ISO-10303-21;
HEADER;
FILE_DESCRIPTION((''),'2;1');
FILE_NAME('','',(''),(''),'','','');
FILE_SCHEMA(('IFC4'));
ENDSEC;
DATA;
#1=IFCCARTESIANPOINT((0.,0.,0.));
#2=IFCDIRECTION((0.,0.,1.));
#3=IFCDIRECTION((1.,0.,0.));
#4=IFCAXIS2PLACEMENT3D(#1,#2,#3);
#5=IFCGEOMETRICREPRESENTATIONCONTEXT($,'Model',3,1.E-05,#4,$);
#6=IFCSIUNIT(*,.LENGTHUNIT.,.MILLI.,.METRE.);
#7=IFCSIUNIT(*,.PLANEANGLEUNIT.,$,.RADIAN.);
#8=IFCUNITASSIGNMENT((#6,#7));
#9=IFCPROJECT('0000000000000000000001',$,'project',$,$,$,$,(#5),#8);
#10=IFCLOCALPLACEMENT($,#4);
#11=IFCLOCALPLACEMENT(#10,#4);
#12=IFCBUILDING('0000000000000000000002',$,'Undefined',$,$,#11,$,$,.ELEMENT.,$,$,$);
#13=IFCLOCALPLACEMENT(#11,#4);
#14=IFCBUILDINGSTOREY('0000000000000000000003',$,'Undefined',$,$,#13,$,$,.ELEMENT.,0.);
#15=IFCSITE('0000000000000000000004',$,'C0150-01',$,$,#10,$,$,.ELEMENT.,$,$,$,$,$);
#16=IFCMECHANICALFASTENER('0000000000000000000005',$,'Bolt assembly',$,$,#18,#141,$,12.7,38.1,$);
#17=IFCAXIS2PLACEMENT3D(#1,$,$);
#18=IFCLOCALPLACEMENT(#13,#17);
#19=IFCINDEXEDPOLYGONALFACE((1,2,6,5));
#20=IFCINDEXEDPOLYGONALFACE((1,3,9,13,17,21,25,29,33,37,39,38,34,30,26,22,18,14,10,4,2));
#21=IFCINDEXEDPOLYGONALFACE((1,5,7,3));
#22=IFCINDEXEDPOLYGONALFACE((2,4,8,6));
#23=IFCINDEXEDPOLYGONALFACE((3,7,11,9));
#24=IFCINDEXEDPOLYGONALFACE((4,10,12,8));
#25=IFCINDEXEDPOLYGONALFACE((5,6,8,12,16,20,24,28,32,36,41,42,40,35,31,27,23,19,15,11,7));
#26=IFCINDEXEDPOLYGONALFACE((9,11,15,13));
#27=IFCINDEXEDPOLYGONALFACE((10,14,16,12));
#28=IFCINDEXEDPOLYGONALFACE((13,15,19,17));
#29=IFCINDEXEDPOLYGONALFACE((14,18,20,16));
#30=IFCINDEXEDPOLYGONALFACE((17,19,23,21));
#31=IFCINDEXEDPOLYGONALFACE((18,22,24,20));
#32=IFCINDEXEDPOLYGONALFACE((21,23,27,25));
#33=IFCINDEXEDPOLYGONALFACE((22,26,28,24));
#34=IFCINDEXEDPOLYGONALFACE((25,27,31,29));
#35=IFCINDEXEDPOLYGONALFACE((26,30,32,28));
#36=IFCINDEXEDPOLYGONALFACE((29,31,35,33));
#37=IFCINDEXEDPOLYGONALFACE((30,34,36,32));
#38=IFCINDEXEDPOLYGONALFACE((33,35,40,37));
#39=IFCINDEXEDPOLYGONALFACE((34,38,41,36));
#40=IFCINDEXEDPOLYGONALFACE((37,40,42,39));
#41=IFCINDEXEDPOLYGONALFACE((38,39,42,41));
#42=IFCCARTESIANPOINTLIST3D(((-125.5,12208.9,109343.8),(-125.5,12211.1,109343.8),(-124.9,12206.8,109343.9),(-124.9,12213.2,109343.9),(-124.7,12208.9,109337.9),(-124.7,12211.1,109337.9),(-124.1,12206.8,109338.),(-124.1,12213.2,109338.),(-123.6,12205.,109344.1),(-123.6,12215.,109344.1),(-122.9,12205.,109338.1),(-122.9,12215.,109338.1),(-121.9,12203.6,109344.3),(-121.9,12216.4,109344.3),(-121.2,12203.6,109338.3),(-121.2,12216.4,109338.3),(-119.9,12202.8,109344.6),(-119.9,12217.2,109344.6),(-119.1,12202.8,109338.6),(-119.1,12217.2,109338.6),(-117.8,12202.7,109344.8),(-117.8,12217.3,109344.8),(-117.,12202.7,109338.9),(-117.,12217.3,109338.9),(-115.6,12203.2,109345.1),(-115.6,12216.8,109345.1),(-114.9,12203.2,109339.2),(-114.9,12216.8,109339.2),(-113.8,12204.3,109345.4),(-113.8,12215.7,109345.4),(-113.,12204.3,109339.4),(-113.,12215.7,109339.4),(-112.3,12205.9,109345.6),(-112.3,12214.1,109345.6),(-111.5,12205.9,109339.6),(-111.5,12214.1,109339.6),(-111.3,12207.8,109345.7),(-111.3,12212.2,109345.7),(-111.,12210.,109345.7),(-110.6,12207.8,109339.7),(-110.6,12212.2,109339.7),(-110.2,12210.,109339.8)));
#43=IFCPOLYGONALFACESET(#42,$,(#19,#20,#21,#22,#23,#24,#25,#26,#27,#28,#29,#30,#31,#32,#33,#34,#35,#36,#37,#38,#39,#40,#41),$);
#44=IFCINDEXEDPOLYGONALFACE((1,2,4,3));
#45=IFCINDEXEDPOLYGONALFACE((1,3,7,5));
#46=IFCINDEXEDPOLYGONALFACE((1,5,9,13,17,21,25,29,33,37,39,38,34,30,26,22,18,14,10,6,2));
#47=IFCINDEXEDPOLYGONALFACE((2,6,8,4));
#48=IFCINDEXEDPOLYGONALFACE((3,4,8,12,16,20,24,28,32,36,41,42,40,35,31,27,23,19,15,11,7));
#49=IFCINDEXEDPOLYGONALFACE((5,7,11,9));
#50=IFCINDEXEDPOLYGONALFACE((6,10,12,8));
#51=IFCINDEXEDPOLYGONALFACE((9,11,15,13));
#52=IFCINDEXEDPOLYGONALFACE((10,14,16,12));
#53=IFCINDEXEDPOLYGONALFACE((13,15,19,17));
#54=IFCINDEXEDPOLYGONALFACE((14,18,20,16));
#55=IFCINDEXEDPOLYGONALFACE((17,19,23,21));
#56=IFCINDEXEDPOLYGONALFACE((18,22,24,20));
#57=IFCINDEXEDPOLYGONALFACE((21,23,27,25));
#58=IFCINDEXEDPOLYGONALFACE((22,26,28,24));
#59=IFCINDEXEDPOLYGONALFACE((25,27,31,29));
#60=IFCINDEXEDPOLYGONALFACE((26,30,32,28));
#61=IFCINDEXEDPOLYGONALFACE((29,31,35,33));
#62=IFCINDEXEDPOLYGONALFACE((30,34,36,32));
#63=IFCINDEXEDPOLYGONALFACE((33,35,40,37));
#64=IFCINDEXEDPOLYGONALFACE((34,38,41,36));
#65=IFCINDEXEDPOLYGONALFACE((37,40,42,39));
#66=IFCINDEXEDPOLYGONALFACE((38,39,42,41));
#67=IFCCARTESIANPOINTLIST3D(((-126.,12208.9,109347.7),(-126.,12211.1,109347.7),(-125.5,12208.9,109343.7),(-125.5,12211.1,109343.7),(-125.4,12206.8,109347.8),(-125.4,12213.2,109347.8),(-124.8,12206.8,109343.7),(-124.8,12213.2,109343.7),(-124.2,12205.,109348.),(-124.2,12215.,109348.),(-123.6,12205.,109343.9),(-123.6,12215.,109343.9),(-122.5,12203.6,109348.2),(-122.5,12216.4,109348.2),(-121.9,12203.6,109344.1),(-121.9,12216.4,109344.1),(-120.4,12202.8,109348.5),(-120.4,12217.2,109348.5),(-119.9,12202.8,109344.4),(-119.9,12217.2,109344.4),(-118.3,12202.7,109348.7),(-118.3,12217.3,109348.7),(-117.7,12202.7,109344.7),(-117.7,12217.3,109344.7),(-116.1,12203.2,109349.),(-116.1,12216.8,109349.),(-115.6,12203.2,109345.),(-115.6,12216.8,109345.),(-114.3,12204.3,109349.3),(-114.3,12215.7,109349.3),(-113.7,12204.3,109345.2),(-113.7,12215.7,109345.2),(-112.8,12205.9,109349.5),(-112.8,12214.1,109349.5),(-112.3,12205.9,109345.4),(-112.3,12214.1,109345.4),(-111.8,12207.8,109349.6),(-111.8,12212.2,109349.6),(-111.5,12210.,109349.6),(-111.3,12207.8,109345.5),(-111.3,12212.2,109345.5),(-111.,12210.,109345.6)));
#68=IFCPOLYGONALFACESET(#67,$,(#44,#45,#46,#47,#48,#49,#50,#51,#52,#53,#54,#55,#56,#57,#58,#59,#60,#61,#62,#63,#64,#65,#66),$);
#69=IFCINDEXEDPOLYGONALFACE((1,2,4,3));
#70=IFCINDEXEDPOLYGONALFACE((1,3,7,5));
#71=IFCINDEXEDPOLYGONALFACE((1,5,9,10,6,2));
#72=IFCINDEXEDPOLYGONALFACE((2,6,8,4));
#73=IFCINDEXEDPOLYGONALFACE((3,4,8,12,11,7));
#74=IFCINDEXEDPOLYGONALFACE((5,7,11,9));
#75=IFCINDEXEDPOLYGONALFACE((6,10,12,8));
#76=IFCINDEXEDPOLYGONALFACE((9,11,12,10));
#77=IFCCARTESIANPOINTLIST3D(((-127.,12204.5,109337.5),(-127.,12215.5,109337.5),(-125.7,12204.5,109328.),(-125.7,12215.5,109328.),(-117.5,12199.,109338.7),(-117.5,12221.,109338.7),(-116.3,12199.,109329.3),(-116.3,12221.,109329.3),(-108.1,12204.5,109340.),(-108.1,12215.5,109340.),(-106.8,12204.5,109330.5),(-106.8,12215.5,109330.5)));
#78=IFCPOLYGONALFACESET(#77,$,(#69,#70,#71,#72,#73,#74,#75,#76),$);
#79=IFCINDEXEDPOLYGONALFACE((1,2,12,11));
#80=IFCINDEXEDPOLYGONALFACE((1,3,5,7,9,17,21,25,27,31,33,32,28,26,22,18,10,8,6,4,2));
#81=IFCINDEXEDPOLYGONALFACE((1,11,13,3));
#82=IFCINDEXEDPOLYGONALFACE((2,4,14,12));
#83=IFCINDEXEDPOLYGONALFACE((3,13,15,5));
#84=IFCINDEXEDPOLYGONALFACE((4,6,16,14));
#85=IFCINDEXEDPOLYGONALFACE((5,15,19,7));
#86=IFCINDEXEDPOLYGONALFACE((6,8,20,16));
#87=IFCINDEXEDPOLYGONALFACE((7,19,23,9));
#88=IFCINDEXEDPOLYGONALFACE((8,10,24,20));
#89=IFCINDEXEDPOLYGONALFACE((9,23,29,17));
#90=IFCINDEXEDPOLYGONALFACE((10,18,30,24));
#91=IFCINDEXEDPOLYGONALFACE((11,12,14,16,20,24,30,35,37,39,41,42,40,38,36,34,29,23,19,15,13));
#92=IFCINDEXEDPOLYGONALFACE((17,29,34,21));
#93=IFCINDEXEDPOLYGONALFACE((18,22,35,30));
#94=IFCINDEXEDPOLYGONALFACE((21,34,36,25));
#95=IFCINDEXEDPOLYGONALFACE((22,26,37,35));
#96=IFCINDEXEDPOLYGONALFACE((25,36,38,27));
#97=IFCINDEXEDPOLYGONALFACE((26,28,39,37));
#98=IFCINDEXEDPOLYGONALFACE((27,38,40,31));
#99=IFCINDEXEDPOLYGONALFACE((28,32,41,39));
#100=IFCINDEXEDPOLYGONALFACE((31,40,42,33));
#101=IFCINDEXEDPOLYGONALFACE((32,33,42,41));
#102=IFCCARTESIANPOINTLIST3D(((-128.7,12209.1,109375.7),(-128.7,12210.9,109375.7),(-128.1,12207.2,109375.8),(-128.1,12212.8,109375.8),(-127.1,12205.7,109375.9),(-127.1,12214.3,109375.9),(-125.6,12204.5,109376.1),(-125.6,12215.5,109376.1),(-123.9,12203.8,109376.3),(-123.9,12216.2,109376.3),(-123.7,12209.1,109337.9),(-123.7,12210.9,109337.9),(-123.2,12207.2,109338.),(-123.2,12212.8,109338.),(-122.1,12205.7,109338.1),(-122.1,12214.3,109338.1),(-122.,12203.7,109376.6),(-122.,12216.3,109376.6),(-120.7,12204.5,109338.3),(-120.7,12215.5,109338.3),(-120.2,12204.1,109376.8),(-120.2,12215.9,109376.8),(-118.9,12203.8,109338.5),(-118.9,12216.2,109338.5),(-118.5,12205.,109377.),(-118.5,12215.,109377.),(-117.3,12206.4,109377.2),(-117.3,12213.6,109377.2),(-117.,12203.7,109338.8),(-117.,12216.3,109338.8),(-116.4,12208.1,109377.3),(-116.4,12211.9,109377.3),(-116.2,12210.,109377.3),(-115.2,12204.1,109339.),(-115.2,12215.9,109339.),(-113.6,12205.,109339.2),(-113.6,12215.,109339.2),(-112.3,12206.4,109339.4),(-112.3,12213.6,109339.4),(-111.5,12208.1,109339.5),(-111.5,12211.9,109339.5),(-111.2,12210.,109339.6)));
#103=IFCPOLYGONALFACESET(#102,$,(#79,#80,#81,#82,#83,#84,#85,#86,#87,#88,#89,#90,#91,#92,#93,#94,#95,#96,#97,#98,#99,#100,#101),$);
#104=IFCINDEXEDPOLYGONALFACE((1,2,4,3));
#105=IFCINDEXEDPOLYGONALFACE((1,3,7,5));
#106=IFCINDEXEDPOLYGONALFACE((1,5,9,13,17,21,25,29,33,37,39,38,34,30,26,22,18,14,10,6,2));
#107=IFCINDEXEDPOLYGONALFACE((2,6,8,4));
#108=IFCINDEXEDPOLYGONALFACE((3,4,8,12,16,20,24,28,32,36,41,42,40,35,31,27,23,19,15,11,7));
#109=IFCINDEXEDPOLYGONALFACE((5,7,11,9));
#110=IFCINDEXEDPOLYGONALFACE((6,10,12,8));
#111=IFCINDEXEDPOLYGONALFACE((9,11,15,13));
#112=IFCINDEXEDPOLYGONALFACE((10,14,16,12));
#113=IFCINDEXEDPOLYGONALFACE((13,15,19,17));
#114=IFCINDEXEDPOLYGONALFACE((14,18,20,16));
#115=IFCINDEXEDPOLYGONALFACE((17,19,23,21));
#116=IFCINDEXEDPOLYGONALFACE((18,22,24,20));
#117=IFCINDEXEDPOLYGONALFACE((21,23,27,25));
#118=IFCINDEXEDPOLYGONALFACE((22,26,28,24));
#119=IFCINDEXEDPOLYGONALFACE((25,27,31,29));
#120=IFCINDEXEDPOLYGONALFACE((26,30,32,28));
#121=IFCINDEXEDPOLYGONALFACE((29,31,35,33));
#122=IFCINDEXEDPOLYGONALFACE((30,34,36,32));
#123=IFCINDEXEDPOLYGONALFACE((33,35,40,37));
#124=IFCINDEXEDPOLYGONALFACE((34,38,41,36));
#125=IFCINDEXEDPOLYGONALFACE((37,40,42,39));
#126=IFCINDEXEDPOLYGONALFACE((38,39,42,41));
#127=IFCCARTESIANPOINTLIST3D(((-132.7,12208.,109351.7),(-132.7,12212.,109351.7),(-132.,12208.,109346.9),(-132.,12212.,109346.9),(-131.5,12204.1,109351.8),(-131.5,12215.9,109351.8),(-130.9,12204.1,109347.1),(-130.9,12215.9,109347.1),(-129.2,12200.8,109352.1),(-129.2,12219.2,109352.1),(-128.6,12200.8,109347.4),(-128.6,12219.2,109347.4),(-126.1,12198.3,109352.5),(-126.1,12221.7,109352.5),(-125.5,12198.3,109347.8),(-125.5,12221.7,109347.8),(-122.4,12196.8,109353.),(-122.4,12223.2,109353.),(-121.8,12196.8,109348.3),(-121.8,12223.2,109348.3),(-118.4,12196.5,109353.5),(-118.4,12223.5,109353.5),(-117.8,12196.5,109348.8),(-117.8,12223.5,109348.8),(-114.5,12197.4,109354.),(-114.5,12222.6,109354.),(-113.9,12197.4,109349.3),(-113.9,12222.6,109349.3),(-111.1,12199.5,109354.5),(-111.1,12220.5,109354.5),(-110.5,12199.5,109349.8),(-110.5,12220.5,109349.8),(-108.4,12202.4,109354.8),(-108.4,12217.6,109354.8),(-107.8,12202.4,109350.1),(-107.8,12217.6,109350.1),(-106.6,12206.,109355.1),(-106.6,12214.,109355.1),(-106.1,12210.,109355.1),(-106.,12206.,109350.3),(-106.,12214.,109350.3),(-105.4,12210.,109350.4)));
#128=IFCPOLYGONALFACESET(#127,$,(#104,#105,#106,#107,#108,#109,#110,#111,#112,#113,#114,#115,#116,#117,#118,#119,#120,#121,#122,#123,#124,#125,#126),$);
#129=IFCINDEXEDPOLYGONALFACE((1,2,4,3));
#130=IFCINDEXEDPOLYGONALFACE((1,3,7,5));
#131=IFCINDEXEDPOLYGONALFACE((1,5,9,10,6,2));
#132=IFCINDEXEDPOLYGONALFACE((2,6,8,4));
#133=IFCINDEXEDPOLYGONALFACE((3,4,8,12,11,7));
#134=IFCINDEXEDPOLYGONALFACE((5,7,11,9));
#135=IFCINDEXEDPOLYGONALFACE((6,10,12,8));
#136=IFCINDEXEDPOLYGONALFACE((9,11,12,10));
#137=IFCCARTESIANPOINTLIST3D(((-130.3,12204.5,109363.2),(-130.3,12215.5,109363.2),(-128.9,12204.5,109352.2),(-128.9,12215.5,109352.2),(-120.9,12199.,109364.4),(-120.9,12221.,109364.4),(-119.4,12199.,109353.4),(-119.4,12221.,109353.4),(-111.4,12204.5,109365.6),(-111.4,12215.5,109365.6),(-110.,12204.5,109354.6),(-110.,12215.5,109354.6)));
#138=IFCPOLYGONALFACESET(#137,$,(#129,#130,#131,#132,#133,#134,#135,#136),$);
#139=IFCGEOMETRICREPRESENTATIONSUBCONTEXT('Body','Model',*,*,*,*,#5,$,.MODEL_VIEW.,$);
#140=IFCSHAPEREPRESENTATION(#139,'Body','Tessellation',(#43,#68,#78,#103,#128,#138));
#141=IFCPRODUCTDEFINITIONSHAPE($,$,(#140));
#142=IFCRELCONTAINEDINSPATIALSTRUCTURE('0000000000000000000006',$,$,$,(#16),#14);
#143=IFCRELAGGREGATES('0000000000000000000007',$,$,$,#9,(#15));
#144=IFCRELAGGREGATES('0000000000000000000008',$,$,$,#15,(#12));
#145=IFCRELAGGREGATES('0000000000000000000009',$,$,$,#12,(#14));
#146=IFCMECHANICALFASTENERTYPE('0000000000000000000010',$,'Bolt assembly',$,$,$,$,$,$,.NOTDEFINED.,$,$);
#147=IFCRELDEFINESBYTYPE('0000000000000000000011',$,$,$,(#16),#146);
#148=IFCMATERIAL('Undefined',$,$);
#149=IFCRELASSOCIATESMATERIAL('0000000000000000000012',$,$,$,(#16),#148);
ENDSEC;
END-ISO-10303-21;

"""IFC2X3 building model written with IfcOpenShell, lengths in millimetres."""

from ifc_helpers import new_model, si_unit, frame, origin_with_axes, origin_2d_with_axis, place, context, subcontext, project, spatial, polyline, circle, outline, extrude, source, transform, mapped, material, type_object, element, save


model = new_model("IFC2X3")

# Units and contexts
model_context = context("Model", 3, precision=1e-05, world=origin_with_axes())
body_context = subcontext(model_context, "Body", "Model", "MODEL_VIEW")
ifc_project = project(units=[si_unit("LENGTHUNIT", "METRE", prefix="MILLI"), si_unit("PLANEANGLEUNIT", "RADIAN")], contexts=[model_context])

# Site, building, storey
site_placement = place(None, origin_with_axes())
site = spatial("IfcSite", under=ifc_project, at=site_placement, Name="C0150-01", CompositionType="ELEMENT")
building_placement = place(site_placement, origin_with_axes())
building = spatial("IfcBuilding", under=site, at=building_placement, Name="Undefined", CompositionType="ELEMENT")
storey_placement = place(building_placement, origin_with_axes())
storey = spatial("IfcBuildingStorey", under=building, at=storey_placement, Name="Undefined", CompositionType="ELEMENT", Elevation=0.0)

# Mechanical fastener
ifc_material_1 = material(Name="Undefined")
mechanical_fastener_type = type_object("IfcMechanicalFastenerType", Name="Bolt assembly")
shared_shape_1 = source(origin_with_axes(), body_context, "Body", "SweptSolid", [
    extrude(circle(Radius=7.3, at=origin_2d_with_axis()), frame((0.0, -9.9, 0.0), z_axis=(0.0, 1.0, 0.0), x_axis=(1.0, 0.0, 0.0)), (0.0, 0.0, 1.0), 6.0),
    extrude(circle(Radius=7.3, at=origin_2d_with_axis()), frame((0.0, -4.1, 0.0), z_axis=(0.0, 1.0, 0.0), x_axis=(1.0, 0.0, 0.0)), (0.0, 0.0, 1.0), 4.1),
    extrude(outline(polyline([(9.5, -5.5), (9.5, 5.5), (0.0, 11.0), (-9.5, 5.5), (-9.5, -5.5), (0.0, -11.0), (9.5, -5.5)])), frame((0.0, -19.5, 0.0), z_axis=(0.0, 1.0, 0.0), x_axis=(1.0, 0.0, 0.0)), (0.0, 0.0, 1.0), 9.5),
    extrude(circle(Radius=6.3, at=origin_2d_with_axis()), frame((0.0, -10.0, 0.0), z_axis=(0.0, 1.0, 0.0), x_axis=(1.0, 0.0, 0.0)), (0.0, 0.0, 1.0), 38.1),
    extrude(circle(Radius=13.5, at=origin_2d_with_axis()), frame((0.0, 0.0, 0.0), z_axis=(0.0, 1.0, 0.0), x_axis=(1.0, 0.0, 0.0)), (0.0, 0.0, 1.0), 4.8),
    extrude(outline(polyline([(9.5, -5.5), (9.5, 5.5), (0.0, 11.0), (-9.5, 5.5), (-9.5, -5.5), (0.0, -11.0), (9.5, -5.5)])), frame((0.0, 4.8, 0.0), z_axis=(0.0, 1.0, 0.0), x_axis=(1.0, 0.0, 0.0)), (0.0, 0.0, 1.0), 11.1),
])
mechanical_fastener_1_placement = place(storey_placement, frame((-118.8, 12210.0, 109348.6), z_axis=(0.0, -1.0, 0.0), x_axis=(0.991507, 0.0, 0.130054)))
element("IfcMechanicalFastener", 1, at=mechanical_fastener_1_placement, inside=storey, type_object=mechanical_fastener_type, material=ifc_material_1, Name="Bolt assembly", NominalDiameter=12.7, NominalLength=38.1, context=body_context, shape_type="MappedRepresentation", body=[
    mapped(shared_shape_1, transform((0.0, 0.0, 0.0))),
])

save(model, "model.ifc")
